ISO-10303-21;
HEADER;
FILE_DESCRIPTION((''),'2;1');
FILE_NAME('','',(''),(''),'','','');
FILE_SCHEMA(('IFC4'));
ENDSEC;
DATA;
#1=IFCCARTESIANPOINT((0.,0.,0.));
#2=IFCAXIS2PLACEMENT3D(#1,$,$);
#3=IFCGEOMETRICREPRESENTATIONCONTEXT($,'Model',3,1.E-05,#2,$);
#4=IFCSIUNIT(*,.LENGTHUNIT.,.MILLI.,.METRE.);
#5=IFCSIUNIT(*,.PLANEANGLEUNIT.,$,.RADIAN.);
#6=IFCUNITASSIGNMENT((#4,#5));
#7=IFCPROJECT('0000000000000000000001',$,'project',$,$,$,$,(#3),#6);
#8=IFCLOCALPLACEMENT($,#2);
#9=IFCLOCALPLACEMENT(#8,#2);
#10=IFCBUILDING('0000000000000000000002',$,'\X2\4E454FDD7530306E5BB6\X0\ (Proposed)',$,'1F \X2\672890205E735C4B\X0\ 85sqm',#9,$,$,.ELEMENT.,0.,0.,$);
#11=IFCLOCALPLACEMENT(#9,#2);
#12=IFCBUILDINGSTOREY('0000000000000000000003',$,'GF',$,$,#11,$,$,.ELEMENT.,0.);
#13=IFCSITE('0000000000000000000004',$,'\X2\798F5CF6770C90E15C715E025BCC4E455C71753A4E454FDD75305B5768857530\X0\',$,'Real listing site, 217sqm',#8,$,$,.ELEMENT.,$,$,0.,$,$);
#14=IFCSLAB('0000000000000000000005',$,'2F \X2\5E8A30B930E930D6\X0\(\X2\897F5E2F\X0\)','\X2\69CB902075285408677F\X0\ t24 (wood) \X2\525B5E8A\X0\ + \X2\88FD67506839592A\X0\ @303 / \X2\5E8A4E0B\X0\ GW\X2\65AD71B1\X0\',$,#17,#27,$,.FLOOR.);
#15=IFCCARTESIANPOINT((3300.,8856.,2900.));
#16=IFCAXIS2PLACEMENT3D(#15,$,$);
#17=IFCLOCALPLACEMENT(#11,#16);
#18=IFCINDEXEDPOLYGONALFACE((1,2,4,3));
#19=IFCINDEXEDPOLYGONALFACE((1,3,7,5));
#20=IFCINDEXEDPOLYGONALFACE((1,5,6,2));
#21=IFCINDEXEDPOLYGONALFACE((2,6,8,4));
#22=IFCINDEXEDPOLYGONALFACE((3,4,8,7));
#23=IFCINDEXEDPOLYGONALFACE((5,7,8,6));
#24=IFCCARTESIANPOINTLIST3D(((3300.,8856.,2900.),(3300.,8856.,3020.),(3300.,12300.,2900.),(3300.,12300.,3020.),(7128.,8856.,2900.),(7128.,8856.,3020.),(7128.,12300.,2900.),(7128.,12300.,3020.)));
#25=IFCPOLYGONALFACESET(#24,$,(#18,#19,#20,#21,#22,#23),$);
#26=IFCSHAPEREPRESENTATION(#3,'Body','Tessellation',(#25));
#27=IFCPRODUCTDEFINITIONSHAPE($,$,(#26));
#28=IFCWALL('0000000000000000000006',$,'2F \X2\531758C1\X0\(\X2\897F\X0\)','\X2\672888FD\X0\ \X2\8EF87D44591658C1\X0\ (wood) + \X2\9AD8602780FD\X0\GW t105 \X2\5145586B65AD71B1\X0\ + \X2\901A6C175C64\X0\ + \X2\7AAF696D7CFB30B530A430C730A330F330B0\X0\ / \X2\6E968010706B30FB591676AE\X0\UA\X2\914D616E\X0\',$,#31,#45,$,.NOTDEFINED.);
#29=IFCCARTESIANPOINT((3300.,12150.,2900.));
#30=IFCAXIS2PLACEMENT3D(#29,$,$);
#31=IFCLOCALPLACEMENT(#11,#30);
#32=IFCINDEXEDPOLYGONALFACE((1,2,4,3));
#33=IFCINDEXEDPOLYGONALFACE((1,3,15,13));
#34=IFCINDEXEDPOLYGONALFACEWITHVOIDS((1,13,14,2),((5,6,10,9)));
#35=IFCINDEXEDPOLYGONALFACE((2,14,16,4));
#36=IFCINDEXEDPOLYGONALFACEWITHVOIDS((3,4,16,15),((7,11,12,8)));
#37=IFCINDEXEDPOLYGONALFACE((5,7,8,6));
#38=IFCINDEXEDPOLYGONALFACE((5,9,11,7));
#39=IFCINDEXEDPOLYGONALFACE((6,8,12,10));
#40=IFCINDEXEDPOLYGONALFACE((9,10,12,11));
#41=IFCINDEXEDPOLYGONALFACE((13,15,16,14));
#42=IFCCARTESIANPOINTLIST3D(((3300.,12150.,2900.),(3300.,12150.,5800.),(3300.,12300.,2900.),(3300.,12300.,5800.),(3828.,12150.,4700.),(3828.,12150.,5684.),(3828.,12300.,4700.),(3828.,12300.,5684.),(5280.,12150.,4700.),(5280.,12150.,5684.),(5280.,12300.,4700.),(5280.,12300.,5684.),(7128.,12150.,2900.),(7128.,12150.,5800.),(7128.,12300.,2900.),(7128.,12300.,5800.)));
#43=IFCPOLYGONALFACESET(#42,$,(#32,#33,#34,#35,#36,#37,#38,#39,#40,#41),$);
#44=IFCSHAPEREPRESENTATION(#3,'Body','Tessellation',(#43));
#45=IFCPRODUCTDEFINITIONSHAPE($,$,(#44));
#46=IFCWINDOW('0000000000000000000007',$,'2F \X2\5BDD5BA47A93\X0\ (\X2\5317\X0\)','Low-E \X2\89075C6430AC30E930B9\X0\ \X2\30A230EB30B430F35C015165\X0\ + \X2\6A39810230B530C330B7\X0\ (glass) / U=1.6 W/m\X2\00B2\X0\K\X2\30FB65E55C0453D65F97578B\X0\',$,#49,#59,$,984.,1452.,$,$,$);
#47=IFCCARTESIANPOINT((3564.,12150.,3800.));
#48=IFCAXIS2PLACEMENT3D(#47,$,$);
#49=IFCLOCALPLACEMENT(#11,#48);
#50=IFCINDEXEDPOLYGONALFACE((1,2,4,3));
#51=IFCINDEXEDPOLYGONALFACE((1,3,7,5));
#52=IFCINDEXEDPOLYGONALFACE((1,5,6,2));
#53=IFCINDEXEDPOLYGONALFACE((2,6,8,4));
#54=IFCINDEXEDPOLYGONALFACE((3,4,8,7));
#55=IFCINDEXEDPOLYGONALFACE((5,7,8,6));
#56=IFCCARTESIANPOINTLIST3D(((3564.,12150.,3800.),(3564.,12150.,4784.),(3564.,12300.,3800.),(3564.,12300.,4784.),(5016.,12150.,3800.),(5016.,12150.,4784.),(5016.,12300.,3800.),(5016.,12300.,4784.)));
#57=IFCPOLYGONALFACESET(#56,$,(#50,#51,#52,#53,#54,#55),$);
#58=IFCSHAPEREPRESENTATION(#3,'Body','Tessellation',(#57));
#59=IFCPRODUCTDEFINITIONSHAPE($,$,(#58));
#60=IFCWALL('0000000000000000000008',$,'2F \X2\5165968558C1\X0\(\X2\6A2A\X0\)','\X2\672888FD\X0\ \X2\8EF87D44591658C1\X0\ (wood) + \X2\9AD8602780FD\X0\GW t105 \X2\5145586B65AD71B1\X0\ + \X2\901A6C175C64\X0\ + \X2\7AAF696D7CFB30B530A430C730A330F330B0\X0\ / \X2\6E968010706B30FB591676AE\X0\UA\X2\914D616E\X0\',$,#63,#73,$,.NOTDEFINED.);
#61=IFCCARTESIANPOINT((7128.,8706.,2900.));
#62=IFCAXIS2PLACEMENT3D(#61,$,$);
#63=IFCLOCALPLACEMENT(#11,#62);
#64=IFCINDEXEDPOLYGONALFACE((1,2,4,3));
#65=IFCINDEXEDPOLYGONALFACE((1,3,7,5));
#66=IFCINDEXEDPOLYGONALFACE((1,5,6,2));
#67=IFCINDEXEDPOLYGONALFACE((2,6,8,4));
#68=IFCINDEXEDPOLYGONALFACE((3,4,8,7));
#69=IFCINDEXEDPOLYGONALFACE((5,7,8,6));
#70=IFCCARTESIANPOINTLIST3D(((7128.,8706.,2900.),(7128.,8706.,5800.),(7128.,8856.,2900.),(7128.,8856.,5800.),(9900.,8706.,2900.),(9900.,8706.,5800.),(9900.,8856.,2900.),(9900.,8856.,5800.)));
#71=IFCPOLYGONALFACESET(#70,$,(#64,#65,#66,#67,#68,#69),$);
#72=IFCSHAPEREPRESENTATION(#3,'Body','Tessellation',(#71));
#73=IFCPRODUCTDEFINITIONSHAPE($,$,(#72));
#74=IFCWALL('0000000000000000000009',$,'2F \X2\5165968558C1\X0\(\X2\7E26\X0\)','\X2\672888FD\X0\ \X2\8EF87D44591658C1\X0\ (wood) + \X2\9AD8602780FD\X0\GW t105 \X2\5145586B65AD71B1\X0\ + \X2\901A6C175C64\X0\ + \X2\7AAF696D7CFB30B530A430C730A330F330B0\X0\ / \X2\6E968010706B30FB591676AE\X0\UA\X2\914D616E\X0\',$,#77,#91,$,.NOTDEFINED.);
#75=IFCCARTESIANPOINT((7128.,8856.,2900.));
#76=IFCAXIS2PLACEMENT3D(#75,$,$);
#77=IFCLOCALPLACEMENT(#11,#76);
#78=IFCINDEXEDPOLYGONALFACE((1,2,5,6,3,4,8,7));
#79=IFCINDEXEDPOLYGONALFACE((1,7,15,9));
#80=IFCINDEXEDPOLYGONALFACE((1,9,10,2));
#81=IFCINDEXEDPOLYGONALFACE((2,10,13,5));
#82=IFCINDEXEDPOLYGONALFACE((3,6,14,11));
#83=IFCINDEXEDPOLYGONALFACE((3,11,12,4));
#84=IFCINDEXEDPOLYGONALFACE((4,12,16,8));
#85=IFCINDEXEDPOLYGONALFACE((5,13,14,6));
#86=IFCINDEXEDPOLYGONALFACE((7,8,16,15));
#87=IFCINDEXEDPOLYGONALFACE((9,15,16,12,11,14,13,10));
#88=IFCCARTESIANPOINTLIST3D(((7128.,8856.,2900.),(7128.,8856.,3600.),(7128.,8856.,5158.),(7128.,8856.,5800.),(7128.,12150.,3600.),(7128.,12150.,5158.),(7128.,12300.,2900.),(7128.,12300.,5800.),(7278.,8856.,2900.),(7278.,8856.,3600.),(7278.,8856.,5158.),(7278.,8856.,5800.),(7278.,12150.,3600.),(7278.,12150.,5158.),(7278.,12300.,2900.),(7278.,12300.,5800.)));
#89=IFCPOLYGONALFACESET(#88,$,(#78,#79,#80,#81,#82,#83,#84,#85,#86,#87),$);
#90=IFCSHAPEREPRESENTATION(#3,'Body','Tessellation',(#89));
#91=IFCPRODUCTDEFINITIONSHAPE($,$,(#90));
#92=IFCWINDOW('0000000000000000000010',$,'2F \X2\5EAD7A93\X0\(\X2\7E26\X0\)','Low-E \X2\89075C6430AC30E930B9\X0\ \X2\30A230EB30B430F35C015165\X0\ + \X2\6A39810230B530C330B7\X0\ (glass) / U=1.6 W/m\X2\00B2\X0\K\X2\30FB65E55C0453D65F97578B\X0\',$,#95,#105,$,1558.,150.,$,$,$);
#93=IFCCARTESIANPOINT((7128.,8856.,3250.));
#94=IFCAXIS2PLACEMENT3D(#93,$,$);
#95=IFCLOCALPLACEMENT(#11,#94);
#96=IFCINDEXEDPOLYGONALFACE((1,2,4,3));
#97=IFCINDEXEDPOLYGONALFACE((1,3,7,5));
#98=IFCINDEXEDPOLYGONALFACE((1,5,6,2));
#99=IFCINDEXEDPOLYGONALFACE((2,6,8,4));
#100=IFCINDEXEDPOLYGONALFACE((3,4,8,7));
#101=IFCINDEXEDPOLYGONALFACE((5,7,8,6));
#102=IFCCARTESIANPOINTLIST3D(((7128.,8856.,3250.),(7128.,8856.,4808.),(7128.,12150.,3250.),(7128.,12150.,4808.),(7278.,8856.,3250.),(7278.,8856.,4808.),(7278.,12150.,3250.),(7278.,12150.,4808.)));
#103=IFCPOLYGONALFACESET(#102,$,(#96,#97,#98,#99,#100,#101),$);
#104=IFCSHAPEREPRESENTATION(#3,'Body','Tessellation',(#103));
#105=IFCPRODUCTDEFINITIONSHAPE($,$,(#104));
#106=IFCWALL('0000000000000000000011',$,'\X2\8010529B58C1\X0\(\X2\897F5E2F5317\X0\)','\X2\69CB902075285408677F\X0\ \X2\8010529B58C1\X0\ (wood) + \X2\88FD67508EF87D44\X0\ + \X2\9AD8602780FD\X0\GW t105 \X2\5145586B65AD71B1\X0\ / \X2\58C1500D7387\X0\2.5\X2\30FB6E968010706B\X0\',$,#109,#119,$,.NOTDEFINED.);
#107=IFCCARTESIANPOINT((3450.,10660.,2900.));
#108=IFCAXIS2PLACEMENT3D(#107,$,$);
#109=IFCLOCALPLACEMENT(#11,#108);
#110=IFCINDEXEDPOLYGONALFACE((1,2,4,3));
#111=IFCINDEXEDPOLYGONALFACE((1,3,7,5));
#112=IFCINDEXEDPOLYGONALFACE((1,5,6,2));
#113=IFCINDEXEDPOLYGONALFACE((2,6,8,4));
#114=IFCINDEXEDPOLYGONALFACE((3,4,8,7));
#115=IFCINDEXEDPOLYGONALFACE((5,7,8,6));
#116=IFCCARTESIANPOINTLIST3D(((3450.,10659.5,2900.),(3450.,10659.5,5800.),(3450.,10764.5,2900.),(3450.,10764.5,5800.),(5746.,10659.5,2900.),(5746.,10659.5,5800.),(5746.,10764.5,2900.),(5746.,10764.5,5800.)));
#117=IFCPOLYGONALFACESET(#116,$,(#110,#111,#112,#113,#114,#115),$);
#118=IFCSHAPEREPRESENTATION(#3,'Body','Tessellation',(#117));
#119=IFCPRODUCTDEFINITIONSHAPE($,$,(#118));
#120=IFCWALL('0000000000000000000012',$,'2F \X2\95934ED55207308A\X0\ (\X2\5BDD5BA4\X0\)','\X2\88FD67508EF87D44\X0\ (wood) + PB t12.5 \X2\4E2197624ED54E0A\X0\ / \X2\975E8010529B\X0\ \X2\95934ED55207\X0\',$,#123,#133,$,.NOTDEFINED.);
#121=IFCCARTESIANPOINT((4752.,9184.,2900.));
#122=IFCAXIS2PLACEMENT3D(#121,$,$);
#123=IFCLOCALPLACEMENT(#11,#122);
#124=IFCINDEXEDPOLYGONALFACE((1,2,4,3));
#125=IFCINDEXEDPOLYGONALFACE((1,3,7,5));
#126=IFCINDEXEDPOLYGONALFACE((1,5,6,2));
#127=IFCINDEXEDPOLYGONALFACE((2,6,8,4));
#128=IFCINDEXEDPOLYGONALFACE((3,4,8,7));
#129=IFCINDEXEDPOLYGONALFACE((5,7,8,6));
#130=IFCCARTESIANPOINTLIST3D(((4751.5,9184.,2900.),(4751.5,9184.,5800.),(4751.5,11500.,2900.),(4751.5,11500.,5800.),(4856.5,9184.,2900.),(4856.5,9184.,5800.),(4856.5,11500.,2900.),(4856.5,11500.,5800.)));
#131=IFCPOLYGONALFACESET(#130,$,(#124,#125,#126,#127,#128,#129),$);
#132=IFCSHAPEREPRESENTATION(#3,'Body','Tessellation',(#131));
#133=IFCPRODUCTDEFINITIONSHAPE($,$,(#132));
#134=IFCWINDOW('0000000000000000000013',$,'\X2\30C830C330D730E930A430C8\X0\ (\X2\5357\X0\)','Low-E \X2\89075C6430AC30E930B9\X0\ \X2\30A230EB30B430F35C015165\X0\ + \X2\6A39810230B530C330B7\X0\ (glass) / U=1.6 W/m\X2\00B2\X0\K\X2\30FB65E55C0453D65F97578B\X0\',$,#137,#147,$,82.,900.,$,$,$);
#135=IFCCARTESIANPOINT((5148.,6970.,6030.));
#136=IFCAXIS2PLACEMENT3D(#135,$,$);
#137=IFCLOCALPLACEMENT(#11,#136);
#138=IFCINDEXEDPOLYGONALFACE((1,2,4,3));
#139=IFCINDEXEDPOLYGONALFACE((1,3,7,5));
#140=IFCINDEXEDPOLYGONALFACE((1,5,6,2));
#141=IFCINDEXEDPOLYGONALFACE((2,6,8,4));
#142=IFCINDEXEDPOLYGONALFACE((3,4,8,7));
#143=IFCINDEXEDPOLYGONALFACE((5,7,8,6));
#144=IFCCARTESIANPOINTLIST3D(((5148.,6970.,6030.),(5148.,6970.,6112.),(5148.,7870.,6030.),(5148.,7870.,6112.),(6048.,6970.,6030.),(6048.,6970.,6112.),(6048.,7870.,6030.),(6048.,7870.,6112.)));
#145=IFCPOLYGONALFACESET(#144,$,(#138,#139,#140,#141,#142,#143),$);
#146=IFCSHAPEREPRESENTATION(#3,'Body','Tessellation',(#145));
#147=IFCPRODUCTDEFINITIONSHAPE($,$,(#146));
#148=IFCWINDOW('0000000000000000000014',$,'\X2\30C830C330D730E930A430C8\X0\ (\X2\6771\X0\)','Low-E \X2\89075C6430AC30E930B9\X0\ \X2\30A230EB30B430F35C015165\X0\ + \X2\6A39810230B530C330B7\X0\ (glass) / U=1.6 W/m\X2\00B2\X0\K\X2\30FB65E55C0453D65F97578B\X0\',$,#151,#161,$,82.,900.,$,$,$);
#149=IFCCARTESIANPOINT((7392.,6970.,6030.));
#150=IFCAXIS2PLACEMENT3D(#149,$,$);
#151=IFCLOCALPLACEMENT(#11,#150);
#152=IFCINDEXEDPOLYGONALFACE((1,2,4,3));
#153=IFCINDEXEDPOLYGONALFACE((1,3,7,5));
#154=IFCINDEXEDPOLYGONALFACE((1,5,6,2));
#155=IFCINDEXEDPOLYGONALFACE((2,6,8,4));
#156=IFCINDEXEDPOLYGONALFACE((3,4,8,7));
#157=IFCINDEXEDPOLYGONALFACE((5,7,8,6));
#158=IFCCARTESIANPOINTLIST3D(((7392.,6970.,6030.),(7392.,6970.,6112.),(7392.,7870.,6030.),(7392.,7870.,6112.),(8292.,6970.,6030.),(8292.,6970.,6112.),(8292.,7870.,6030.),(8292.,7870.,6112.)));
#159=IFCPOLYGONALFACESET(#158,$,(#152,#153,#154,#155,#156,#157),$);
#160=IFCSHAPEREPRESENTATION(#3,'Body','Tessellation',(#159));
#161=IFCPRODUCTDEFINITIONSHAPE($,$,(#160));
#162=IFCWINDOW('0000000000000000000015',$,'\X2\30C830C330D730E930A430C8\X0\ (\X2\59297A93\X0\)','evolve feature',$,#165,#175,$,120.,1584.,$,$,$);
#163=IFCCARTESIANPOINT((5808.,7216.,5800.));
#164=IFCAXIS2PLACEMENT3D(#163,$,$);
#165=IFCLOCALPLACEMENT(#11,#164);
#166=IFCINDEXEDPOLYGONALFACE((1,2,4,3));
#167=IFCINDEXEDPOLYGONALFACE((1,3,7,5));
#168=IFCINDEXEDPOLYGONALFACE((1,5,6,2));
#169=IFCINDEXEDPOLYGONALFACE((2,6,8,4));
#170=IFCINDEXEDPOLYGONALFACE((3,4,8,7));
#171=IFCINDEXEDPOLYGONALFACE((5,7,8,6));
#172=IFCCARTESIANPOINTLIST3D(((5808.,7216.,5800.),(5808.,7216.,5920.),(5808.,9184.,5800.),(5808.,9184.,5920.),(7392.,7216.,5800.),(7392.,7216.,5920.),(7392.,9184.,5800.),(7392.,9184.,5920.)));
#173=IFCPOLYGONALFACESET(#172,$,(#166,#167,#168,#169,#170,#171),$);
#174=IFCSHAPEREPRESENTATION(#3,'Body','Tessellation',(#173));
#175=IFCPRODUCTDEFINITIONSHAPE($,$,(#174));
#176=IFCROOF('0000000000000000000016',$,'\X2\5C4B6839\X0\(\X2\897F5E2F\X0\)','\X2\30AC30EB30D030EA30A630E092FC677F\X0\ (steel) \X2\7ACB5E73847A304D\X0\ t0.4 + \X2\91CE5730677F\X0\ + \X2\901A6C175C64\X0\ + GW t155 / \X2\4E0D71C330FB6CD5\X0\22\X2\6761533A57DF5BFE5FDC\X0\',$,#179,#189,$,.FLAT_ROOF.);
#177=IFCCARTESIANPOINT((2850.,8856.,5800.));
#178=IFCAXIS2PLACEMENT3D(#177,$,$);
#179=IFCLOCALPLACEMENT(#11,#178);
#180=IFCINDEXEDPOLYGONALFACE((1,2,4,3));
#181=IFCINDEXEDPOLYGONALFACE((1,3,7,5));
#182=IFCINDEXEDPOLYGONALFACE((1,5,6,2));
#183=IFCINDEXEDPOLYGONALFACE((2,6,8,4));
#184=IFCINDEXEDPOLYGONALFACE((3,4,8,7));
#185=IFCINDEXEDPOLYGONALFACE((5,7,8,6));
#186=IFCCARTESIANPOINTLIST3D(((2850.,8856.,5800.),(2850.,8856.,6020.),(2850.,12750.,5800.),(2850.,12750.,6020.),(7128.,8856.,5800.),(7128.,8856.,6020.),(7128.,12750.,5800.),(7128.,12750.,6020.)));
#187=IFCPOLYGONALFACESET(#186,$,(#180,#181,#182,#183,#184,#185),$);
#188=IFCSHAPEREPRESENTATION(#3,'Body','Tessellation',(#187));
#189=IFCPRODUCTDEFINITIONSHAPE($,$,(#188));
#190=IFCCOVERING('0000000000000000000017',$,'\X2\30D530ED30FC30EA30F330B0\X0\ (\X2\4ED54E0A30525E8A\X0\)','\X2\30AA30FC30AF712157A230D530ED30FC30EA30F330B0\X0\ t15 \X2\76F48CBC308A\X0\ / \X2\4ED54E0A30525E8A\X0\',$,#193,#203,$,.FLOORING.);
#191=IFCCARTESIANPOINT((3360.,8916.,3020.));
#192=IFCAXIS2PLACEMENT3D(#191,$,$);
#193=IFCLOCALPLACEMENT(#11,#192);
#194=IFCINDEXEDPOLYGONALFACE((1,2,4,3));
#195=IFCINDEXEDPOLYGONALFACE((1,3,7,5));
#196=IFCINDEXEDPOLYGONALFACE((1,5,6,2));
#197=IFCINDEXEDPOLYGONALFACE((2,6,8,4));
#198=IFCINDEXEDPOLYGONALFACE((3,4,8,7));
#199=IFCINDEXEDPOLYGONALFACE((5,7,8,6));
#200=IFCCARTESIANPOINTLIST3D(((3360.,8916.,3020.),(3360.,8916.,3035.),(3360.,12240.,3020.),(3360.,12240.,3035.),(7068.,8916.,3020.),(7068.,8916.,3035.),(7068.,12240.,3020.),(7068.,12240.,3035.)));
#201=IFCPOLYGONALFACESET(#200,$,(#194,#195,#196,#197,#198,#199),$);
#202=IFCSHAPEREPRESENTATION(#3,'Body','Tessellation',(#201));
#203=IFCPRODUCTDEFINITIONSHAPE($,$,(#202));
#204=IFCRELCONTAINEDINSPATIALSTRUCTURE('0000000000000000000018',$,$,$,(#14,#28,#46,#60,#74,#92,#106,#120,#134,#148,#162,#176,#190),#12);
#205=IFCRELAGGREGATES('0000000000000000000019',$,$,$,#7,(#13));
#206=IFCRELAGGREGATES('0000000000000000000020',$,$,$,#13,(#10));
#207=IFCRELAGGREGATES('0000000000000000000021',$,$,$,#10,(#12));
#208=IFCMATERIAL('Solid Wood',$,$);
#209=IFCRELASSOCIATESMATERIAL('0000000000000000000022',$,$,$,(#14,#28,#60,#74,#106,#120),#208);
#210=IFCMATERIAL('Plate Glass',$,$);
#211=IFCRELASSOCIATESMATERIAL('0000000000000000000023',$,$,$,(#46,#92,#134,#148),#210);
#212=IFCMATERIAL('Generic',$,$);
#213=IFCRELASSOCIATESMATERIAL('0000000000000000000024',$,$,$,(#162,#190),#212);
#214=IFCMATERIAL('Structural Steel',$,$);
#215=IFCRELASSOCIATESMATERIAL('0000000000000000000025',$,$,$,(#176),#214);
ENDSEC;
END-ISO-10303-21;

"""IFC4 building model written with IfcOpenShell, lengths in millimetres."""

from ifc_helpers import new_model, si_unit, frame, frame_2d, origin, place, context, project, spatial, rectangle, extrude, material, element, fill, save


model = new_model("IFC4")

# Units and contexts
model_context = context("Model", 3, precision=1e-05, world=origin())
ifc_project = project(units=[si_unit("LENGTHUNIT", "METRE", prefix="MILLI"), si_unit("PLANEANGLEUNIT", "RADIAN")], contexts=[model_context])

# Site, building, storey
site_placement = place(None, origin())
site = spatial("IfcSite", under=ifc_project, at=site_placement, Name="福島県郡山市富久山町久保田字梅田", ObjectType="Real listing site, 217sqm", CompositionType="ELEMENT", RefElevation=0.0)
building_placement = place(site_placement, origin())
building = spatial("IfcBuilding", under=site, at=building_placement, Name="久保田の家 (Proposed)", ObjectType="1F 木造平屋 85sqm", CompositionType="ELEMENT", ElevationOfRefHeight=0.0, ElevationOfTerrain=0.0)
storey_placement = place(building_placement, origin())
storey = spatial("IfcBuildingStorey", under=building, at=storey_placement, Name="GF", CompositionType="ELEMENT", Elevation=0.0)

# Slab
ifc_material_1 = material(Name="Solid Wood")
slab_placement = place(storey_placement, frame((3300.0, 8856.0, 2900.0)))
element("IfcSlab", 1, at=slab_placement, inside=storey, material=ifc_material_1, Name="2F 床スラブ(西帯)", Description="構造用合板 t24 (wood) 剛床 + 製材根太 @303 / 床下 GW断熱", PredefinedType="FLOOR", context=model_context, shape_type="SweptSolid", body=[
    extrude(rectangle(XDim=3828.0, YDim=3444.0, at=frame_2d((1914.0, 1722.0))), frame((3300.0, 8856.0, 2900.0)), (0.0, 0.0, 1.0), 120.0),
])

# Wall, opening, window
wall_1_placement = place(storey_placement, frame((3300.0, 12150.0, 2900.0)))
wall_1 = element("IfcWall", 2, at=wall_1_placement, inside=storey, material=ifc_material_1, Name="2F 北壁(西)", Description="木製 軸組外壁 (wood) + 高性能GW t105 充填断熱 + 通気層 + 窯業系サイディング / 準耐火・外皮UA配慮", PredefinedType="NOTDEFINED", context=model_context, shape_type="SweptSolid", body=[
    extrude(rectangle(XDim=3828.0, YDim=150.0, at=frame_2d((1914.0, 75.0))), frame((3300.0, 12150.0, 2900.0)), (0.0, 0.0, 1.0), 2900.0),
])
opening_1_placement = place(storey_placement, frame((3564.0, 12150.0, 3800.0)))
opening_1 = element("IfcOpeningElement", 3, at=opening_1_placement, cuts=wall_1, PredefinedType="NOTDEFINED", context=model_context, shape_type="SweptSolid", body=[
    extrude(rectangle(XDim=1452.0, YDim=150.0, at=frame_2d((726.0, 75.0))), frame((3564.0, 12150.0, 3800.0)), (0.0, 0.0, 1.0), 984.0),
])
ifc_material_2 = material(Name="Plate Glass")
window_1_placement = place(storey_placement, frame((3564.0, 12150.0, 3800.0)))
window_1 = element("IfcWindow", 4, at=window_1_placement, inside=storey, material=ifc_material_2, Name="2F 寝室窓 (北)", Description="Low-E 複層ガラス アルゴン封入 + 樹脂サッシ (glass) / U=1.6 W/m²K・日射取得型", OverallHeight=984.0, OverallWidth=1452.0, context=model_context, shape_type="SweptSolid", body=[
    extrude(rectangle(XDim=1452.0, YDim=150.0, at=frame_2d((726.0, 75.0))), frame((3564.0, 12150.0, 3800.0)), (0.0, 0.0, 1.0), 984.0),
])
fill(opening_1, window_1)

# Wall
wall_2_placement = place(storey_placement, frame((7128.0, 8706.0, 2900.0)))
element("IfcWall", 5, at=wall_2_placement, inside=storey, material=ifc_material_1, Name="2F 入隅壁(横)", Description="木製 軸組外壁 (wood) + 高性能GW t105 充填断熱 + 通気層 + 窯業系サイディング / 準耐火・外皮UA配慮", PredefinedType="NOTDEFINED", context=model_context, shape_type="SweptSolid", body=[
    extrude(rectangle(XDim=2772.0, YDim=150.0, at=frame_2d((1386.0, 75.0))), frame((7128.0, 8706.0, 2900.0)), (0.0, 0.0, 1.0), 2900.0),
])

# Wall, opening, window
wall_3_placement = place(storey_placement, frame((7128.0, 8856.0, 2900.0)))
wall_3 = element("IfcWall", 6, at=wall_3_placement, inside=storey, material=ifc_material_1, Name="2F 入隅壁(縦)", Description="木製 軸組外壁 (wood) + 高性能GW t105 充填断熱 + 通気層 + 窯業系サイディング / 準耐火・外皮UA配慮", PredefinedType="NOTDEFINED", context=model_context, shape_type="SweptSolid", body=[
    extrude(rectangle(XDim=150.0, YDim=3444.0, at=frame_2d((75.0, 1722.0))), frame((7128.0, 8856.0, 2900.0)), (0.0, 0.0, 1.0), 2900.0),
])
opening_2_placement = place(storey_placement, frame((7128.0, 8856.0, 3250.0)))
opening_2 = element("IfcOpeningElement", 7, at=opening_2_placement, cuts=wall_3, PredefinedType="NOTDEFINED", context=model_context, shape_type="SweptSolid", body=[
    extrude(rectangle(XDim=150.0, YDim=3294.0, at=frame_2d((75.0, 1647.0))), frame((7128.0, 8856.0, 3250.0)), (0.0, 0.0, 1.0), 1558.0),
])
window_2_placement = place(storey_placement, frame((7128.0, 8856.0, 3250.0)))
window_2 = element("IfcWindow", 8, at=window_2_placement, inside=storey, material=ifc_material_2, Name="2F 庭窓(縦)", Description="Low-E 複層ガラス アルゴン封入 + 樹脂サッシ (glass) / U=1.6 W/m²K・日射取得型", OverallHeight=1558.0, OverallWidth=150.0, context=model_context, shape_type="SweptSolid", body=[
    extrude(rectangle(XDim=150.0, YDim=3294.0, at=frame_2d((75.0, 1647.0))), frame((7128.0, 8856.0, 3250.0)), (0.0, 0.0, 1.0), 1558.0),
])
fill(opening_2, window_2)

# Walls
wall_4_placement = place(storey_placement, frame((3450.0, 10660.0, 2900.0)))
element("IfcWall", 9, at=wall_4_placement, inside=storey, material=ifc_material_1, Name="耐力壁(西帯北)", Description="構造用合板 耐力壁 (wood) + 製材軸組 + 高性能GW t105 充填断熱 / 壁倍率2.5・準耐火", PredefinedType="NOTDEFINED", context=model_context, shape_type="SweptSolid", body=[
    extrude(rectangle(XDim=2296.0, YDim=105.0, at=frame_2d((1148.0, 52.0))), frame((3450.0, 10660.0, 2900.0)), (0.0, 0.0, 1.0), 2900.0),
])
wall_5_placement = place(storey_placement, frame((4752.0, 9184.0, 2900.0)))
element("IfcWall", 10, at=wall_5_placement, inside=storey, material=ifc_material_1, Name="2F 間仕切り (寝室)", Description="製材軸組 (wood) + PB t12.5 両面仕上 / 非耐力 間仕切", PredefinedType="NOTDEFINED", context=model_context, shape_type="SweptSolid", body=[
    extrude(rectangle(XDim=105.0, YDim=2316.0, at=frame_2d((52.0, 1158.0))), frame((4752.0, 9184.0, 2900.0)), (0.0, 0.0, 1.0), 2900.0),
])

# Windows
window_3_placement = place(storey_placement, frame((5148.0, 6970.0, 6030.0)))
element("IfcWindow", 11, at=window_3_placement, inside=storey, material=ifc_material_2, Name="トップライト (南)", Description="Low-E 複層ガラス アルゴン封入 + 樹脂サッシ (glass) / U=1.6 W/m²K・日射取得型", OverallHeight=82.0, OverallWidth=900.0, context=model_context, shape_type="SweptSolid", body=[
    extrude(rectangle(XDim=900.0, YDim=900.0, at=frame_2d((450.0, 450.0))), frame((5148.0, 6970.0, 6030.0)), (0.0, 0.0, 1.0), 82.0),
])
window_4_placement = place(storey_placement, frame((7392.0, 6970.0, 6030.0)))
element("IfcWindow", 12, at=window_4_placement, inside=storey, material=ifc_material_2, Name="トップライト (東)", Description="Low-E 複層ガラス アルゴン封入 + 樹脂サッシ (glass) / U=1.6 W/m²K・日射取得型", OverallHeight=82.0, OverallWidth=900.0, context=model_context, shape_type="SweptSolid", body=[
    extrude(rectangle(XDim=900.0, YDim=900.0, at=frame_2d((450.0, 450.0))), frame((7392.0, 6970.0, 6030.0)), (0.0, 0.0, 1.0), 82.0),
])
ifc_material_3 = material(Name="Generic")
window_5_placement = place(storey_placement, frame((5808.0, 7216.0, 5800.0)))
element("IfcWindow", 13, at=window_5_placement, inside=storey, material=ifc_material_3, Name="トップライト (天窓)", Description="evolve feature", OverallHeight=120.0, OverallWidth=1584.0, context=model_context, shape_type="SweptSolid", body=[
    extrude(rectangle(XDim=1584.0, YDim=1968.0, at=frame_2d((792.0, 984.0))), frame((5808.0, 7216.0, 5800.0)), (0.0, 0.0, 1.0), 120.0),
])

# Roof
ifc_material_4 = material(Name="Structural Steel")
for number, where, name in (
    (14, (2850.0, 8856.0, 5800.0), "屋根(西帯)"),
):
    element("IfcRoof", number, at=place(storey_placement, frame(where)), inside=storey, material=ifc_material_4, Name=name, Description="ガルバリウム鋼板 (steel) 立平葺き t0.4 + 野地板 + 通気層 + GW t155 / 不燃・法22条区域対応", PredefinedType="FLAT_ROOF", context=model_context, shape_type="SweptSolid", body=[
        extrude(rectangle(XDim=4278.0, YDim=3894.0, at=frame_2d((2139.0, 1947.0))), frame((2850.0, 8856.0, 5800.0)), (0.0, 0.0, 1.0), 220.0),
    ])

# Covering
covering_placement = place(storey_placement, frame((3360.0, 8916.0, 3020.0)))
element("IfcCovering", 15, at=covering_placement, inside=storey, material=ifc_material_3, Name="フローリング (仕上げ床)", Description="オーク無垢フローリング t15 直貼り / 仕上げ床", PredefinedType="FLOORING", context=model_context, shape_type="SweptSolid", body=[
    extrude(rectangle(XDim=3708.0, YDim=3324.0, at=frame_2d((1854.0, 1662.0))), frame((3360.0, 8916.0, 3020.0)), (0.0, 0.0, 1.0), 15.0),
])

save(model, "model.ifc")
